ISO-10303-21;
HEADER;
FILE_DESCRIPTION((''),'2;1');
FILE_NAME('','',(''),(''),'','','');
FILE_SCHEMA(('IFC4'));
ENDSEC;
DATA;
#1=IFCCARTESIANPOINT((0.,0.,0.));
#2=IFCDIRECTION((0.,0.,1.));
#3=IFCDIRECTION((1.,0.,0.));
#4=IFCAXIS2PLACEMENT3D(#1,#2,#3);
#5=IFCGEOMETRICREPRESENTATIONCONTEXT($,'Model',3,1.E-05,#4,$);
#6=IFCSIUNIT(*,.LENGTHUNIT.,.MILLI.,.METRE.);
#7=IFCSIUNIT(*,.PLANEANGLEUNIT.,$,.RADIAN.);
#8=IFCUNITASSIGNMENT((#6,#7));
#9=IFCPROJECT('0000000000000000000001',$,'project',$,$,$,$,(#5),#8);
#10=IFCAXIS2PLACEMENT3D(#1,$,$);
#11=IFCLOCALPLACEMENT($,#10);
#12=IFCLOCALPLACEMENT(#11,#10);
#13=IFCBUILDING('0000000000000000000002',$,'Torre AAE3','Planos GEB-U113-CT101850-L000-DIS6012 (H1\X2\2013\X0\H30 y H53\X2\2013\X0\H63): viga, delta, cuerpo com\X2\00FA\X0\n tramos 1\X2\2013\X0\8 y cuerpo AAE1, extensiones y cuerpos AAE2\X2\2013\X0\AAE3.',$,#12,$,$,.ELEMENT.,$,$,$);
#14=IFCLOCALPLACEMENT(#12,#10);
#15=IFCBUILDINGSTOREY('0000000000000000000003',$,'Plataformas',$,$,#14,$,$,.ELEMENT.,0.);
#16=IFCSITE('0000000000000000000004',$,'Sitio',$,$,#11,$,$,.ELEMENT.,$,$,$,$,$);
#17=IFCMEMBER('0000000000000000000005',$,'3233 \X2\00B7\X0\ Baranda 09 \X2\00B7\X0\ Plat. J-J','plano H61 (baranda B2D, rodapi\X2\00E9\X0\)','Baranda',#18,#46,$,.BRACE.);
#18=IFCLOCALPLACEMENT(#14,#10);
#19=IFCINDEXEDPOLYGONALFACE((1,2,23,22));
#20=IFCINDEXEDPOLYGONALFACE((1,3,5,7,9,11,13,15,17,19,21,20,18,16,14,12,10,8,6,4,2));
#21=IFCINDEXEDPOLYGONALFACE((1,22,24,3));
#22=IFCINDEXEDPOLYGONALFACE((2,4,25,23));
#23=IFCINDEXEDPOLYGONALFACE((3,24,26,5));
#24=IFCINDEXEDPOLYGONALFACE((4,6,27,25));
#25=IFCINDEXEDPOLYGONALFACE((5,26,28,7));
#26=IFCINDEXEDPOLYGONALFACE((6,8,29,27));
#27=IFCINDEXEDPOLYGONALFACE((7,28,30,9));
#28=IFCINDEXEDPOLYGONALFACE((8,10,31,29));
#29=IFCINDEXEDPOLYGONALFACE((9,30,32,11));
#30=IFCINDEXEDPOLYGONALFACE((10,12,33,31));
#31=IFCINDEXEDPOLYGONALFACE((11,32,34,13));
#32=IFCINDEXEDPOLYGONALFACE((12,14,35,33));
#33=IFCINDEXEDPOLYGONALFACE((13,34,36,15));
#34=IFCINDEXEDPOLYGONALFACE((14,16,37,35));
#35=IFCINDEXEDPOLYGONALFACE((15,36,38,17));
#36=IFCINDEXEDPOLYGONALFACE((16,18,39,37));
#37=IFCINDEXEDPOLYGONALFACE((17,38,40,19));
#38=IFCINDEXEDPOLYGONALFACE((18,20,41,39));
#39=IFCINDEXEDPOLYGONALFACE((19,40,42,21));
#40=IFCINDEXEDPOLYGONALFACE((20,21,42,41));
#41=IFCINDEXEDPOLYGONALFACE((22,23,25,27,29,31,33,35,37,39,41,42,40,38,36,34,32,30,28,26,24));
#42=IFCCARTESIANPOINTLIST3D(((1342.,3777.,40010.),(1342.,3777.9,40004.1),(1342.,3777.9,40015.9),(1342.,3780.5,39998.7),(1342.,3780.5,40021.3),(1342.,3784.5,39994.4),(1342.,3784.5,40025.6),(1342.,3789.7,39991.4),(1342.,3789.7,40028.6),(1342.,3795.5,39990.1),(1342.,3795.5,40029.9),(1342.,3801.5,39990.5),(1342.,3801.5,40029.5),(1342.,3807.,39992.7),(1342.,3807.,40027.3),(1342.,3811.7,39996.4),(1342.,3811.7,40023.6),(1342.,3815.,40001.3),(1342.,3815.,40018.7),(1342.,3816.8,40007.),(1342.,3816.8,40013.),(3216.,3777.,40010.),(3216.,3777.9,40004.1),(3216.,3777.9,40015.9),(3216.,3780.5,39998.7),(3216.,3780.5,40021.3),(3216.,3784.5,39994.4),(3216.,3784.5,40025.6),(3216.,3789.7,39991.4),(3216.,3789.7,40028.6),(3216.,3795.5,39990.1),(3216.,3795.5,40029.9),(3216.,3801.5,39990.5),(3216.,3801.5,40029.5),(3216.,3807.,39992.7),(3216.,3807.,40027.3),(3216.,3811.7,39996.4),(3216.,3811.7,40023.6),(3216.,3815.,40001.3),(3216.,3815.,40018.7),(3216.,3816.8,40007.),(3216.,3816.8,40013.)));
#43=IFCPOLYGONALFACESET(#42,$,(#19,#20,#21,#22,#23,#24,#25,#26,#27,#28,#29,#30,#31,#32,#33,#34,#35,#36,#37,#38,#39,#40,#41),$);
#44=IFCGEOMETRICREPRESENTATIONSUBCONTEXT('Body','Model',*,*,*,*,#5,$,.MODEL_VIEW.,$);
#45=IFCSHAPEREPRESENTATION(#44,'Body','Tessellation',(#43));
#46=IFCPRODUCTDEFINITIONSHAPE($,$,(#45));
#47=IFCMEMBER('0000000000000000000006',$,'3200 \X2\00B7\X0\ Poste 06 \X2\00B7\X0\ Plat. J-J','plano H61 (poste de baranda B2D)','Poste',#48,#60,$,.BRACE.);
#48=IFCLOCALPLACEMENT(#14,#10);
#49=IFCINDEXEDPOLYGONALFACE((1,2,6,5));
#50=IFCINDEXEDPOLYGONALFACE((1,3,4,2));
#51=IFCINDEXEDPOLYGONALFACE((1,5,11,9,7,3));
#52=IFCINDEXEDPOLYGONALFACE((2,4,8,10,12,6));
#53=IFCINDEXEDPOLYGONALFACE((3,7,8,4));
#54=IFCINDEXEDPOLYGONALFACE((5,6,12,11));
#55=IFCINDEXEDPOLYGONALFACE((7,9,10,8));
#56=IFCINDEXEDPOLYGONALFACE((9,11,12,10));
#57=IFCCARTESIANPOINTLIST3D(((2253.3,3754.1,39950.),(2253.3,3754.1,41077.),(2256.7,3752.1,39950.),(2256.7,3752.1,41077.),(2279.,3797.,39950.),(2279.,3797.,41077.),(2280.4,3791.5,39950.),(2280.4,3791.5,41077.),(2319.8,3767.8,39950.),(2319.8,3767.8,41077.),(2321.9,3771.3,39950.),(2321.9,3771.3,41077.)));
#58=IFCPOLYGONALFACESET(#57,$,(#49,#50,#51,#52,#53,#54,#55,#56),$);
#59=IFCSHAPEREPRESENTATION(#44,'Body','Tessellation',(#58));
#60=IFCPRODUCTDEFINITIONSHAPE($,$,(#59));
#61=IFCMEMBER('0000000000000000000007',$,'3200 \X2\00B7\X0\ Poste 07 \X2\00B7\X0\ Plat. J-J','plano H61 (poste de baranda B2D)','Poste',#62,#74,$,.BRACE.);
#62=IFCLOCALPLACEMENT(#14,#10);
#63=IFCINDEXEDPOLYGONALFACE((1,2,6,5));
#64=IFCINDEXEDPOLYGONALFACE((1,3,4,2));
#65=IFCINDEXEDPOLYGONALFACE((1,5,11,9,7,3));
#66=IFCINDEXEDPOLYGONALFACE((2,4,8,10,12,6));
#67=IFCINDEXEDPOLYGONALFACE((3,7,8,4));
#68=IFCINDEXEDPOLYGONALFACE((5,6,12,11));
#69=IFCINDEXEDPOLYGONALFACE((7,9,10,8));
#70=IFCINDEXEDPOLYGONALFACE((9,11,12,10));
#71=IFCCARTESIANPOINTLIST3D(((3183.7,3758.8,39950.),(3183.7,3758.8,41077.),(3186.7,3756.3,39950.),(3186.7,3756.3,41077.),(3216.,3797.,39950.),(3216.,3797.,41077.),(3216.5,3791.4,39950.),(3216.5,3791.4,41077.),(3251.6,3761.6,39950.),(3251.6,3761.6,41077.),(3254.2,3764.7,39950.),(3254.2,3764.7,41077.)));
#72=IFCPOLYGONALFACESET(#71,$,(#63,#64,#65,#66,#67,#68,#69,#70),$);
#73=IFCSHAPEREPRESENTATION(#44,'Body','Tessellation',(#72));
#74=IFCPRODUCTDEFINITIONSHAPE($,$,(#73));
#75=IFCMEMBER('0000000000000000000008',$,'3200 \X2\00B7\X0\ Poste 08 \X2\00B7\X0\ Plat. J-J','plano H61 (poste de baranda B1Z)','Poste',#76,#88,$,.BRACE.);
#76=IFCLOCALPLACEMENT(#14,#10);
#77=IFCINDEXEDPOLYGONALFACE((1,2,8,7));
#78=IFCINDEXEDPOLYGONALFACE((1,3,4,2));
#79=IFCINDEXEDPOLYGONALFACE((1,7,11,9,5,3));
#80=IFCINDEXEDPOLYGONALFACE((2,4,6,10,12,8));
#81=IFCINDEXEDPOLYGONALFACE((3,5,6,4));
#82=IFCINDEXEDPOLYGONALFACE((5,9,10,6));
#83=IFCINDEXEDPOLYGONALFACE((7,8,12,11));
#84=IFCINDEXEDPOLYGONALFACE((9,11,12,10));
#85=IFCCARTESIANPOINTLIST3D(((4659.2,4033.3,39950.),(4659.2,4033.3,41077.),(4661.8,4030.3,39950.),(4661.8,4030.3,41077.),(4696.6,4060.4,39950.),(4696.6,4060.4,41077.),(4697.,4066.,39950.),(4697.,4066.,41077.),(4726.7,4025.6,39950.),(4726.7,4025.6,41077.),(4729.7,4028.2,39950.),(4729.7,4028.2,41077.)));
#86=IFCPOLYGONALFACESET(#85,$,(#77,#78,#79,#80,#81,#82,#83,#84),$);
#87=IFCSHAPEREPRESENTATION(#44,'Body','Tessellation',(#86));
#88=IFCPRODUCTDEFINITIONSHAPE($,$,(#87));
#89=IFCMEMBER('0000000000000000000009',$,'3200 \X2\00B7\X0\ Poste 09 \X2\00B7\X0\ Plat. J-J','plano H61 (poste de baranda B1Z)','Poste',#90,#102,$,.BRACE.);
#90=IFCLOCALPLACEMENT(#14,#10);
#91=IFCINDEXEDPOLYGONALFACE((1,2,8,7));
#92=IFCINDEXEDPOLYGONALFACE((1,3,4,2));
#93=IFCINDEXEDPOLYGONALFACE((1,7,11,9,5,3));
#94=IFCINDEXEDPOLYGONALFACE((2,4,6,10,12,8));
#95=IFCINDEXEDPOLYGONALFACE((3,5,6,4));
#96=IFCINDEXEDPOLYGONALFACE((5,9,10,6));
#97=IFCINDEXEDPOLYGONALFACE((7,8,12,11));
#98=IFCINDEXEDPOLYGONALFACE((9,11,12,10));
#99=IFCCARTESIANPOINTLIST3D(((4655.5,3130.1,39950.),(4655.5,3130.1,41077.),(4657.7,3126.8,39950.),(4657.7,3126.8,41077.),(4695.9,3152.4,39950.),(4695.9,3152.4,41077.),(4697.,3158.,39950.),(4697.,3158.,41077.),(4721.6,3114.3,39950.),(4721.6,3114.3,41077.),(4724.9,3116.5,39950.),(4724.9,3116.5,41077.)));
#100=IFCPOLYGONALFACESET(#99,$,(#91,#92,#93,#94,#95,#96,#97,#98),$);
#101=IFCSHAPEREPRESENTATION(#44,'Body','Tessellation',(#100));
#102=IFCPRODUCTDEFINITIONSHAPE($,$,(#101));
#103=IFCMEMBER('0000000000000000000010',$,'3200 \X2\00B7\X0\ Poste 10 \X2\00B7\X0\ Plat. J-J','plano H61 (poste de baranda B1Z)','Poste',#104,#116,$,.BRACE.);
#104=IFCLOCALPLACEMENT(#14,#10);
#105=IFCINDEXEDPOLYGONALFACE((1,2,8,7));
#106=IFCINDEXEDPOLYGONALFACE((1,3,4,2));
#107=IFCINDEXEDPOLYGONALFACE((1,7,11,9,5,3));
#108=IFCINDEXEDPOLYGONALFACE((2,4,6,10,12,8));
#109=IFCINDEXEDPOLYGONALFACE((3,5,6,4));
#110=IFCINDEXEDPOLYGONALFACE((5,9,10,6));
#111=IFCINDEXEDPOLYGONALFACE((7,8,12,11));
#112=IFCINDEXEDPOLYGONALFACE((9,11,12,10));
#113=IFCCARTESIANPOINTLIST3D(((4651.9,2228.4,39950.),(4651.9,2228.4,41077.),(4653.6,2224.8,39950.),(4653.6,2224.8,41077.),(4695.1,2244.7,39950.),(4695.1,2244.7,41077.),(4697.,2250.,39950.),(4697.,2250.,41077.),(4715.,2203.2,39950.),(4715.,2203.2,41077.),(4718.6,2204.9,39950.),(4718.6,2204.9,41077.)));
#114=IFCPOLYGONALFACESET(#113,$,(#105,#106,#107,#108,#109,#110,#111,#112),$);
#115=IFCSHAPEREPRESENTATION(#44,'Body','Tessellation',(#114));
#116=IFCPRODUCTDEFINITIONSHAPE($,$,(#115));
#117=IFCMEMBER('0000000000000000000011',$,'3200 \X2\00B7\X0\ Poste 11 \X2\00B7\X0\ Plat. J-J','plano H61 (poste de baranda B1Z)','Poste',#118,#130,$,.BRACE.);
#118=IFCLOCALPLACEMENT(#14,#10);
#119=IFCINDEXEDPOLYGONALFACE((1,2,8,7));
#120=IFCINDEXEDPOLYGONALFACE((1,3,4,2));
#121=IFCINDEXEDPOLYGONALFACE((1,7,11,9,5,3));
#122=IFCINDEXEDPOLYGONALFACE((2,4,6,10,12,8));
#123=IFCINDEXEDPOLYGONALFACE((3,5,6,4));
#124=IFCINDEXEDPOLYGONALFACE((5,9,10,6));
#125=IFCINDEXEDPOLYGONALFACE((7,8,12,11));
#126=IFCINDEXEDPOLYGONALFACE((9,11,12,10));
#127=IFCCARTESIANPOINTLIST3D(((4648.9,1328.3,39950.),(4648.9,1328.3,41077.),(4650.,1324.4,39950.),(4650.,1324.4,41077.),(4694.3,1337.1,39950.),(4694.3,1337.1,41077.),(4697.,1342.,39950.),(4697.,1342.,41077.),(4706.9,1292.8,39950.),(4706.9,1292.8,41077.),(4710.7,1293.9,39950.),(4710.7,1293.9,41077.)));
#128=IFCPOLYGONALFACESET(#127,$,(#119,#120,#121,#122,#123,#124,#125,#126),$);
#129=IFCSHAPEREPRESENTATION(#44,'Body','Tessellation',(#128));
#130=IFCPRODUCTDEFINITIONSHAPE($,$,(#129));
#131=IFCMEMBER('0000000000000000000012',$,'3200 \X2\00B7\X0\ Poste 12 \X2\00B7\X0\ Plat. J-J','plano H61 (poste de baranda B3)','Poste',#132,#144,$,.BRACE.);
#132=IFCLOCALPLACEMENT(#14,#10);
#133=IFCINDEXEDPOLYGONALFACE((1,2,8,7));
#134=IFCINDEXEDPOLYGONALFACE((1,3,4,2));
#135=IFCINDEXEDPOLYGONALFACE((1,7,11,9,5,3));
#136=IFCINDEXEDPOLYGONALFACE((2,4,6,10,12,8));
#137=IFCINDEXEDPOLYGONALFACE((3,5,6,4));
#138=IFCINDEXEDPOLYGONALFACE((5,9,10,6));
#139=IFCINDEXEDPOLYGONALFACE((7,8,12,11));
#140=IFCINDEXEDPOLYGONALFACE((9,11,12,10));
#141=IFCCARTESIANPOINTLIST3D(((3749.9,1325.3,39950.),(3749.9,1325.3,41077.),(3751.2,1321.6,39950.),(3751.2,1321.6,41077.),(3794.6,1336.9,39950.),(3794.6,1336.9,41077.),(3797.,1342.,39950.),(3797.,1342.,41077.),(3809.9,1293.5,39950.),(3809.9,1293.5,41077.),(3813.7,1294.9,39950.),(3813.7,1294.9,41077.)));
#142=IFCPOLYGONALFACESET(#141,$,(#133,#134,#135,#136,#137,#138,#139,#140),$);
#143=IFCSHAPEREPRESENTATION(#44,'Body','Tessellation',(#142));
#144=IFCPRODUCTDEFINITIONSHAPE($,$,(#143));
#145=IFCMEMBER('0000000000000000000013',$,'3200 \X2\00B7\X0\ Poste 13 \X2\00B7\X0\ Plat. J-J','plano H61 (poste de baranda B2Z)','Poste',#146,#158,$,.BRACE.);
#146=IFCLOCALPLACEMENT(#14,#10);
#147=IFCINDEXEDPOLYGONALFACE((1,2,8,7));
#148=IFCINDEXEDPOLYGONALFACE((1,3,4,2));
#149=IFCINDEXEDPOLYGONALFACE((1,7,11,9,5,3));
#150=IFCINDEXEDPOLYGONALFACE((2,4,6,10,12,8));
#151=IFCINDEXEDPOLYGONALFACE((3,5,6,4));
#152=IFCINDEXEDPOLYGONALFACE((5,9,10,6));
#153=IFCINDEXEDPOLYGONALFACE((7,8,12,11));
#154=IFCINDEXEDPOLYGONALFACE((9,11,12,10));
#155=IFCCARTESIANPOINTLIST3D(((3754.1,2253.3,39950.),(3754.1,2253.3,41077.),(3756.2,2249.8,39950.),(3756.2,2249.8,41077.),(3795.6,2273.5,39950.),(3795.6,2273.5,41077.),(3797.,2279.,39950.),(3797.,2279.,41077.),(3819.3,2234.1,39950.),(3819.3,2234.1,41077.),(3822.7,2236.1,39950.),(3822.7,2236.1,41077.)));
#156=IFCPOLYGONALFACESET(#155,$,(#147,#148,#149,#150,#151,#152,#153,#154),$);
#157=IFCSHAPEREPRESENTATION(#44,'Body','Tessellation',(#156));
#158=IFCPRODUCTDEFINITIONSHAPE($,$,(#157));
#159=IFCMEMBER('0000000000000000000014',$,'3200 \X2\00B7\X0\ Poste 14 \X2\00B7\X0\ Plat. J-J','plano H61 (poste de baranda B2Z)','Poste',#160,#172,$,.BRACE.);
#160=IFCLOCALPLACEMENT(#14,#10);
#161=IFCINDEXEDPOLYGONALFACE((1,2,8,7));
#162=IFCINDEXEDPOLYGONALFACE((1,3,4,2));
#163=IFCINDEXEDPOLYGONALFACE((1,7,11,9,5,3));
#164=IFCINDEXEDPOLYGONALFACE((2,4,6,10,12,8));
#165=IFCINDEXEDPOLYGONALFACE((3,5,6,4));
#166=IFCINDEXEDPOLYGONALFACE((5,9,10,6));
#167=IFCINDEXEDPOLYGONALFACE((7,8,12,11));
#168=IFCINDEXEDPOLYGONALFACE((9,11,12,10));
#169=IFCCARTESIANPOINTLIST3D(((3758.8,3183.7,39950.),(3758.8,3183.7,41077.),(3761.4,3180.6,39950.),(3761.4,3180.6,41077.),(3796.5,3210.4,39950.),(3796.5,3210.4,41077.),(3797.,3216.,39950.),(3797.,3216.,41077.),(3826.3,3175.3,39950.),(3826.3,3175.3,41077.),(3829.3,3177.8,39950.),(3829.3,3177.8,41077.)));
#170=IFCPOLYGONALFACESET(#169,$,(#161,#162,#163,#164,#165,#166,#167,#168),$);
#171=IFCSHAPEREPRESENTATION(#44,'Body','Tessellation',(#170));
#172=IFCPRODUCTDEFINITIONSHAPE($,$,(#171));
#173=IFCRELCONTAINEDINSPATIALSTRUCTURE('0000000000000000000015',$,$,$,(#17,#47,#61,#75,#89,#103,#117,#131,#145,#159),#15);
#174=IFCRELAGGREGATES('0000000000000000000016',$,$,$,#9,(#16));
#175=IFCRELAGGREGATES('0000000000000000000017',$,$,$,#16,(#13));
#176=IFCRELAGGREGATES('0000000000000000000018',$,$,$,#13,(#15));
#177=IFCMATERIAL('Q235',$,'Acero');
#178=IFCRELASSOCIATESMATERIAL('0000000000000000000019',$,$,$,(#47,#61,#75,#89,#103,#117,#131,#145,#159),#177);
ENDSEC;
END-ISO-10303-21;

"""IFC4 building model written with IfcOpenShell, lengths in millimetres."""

from ifc_helpers import new_model, si_unit, frame, frame_2d, origin, origin_with_axes, place, context, subcontext, project, spatial, circle, l_section, extrude, material, element, save


model = new_model("IFC4")

# Units and contexts
model_context = context("Model", 3, precision=1e-05, world=origin_with_axes())
body_context = subcontext(model_context, "Body", "Model", "MODEL_VIEW")
ifc_project = project(units=[si_unit("LENGTHUNIT", "METRE", prefix="MILLI"), si_unit("PLANEANGLEUNIT", "RADIAN")], contexts=[model_context])

# Site, building, storey
site_placement = place(None, origin())
site = spatial("IfcSite", under=ifc_project, at=site_placement, Name="Sitio", CompositionType="ELEMENT")
building_placement = place(site_placement, origin())
building = spatial("IfcBuilding", under=site, at=building_placement, Name="Torre AAE3", Description="Planos GEB-U113-CT101850-L000-DIS6012 (H1–H30 y H53–H63): viga, delta, cuerpo común tramos 1–8 y cuerpo AAE1, extensiones y cuerpos AAE2–AAE3.", CompositionType="ELEMENT")
storey_placement = place(building_placement, origin())
storey = spatial("IfcBuildingStorey", under=building, at=storey_placement, Name="Plataformas", CompositionType="ELEMENT", Elevation=0.0)

# Members
ifc_material = material(Name="Q235", Category="Acero")
member_1_placement = place(storey_placement, frame((1342.0, 3797.0, 40010.0), z_axis=(1.0, 0.0, 0.0), x_axis=(0.0, -1.0, 0.0)))
element("IfcMember", 1, at=member_1_placement, inside=storey, Name="3233 · Baranda 09 · Plat. J-J", Description="plano H61 (baranda B2D, rodapié)", ObjectType="Baranda", PredefinedType="BRACE", context=body_context, shape_type="SweptSolid", body=[
    extrude(circle(Radius=20.0), None, (0.0, 0.0, 1.0), 1874.0),
])
for number, where, z_axis, x_axis, name, description in (
    (2, (2279.0, 3797.0, 39950.0), (0.0, 0.0, 1.0), (-0.514629, -0.857413, 0.0), "3200 · Poste 06 · Plat. J-J", "plano H61 (poste de baranda B2D)"),
    (3, (3216.0, 3797.0, 39950.0), (0.0, 0.0, 1.0), (-0.646312, -0.763074, 0.0), "3200 · Poste 07 · Plat. J-J", "plano H61 (poste de baranda B2D)"),
    (4, (4697.0, 4066.0, 39950.0), (0.0, 0.0, 1.0), (-0.756066, -0.654495, 0.0), "3200 · Poste 08 · Plat. J-J", "plano H61 (poste de baranda B1Z)"),
    (5, (4697.0, 3158.0, 39950.0), (0.0, 0.0, 1.0), (-0.829869, -0.557958, 0.0), "3200 · Poste 09 · Plat. J-J", "plano H61 (poste de baranda B1Z)"),
    (6, (4697.0, 2250.0, 39950.0), (0.0, 0.0, 1.0), (-0.901864, -0.432019, 0.0), "3200 · Poste 10 · Plat. J-J", "plano H61 (poste de baranda B1Z)"),
    (7, (4697.0, 1342.0, 39950.0), (0.0, 0.0, 1.0), (-0.961524, -0.274721, 0.0), "3200 · Poste 11 · Plat. J-J", "plano H61 (poste de baranda B1Z)"),
    (8, (3797.0, 1342.0, 39950.0), (0.0, 0.0, 1.0), (-0.942844, -0.333236, 0.0), "3200 · Poste 12 · Plat. J-J", "plano H61 (poste de baranda B3)"),
    (9, (3797.0, 2279.0, 39950.0), (0.0, 0.0, 1.0), (-0.857413, -0.514629, 0.0), "3200 · Poste 13 · Plat. J-J", "plano H61 (poste de baranda B2Z)"),
    (10, (3797.0, 3216.0, 39950.0), (0.0, 0.0, 1.0), (-0.763074, -0.646312, 0.0), "3200 · Poste 14 · Plat. J-J", "plano H61 (poste de baranda B2Z)"),
):
    element("IfcMember", number, at=place(storey_placement, frame(where, z_axis=z_axis, x_axis=x_axis)), inside=storey, material=ifc_material, Name=name, Description=description, ObjectType="Poste", PredefinedType="BRACE", context=body_context, shape_type="SweptSolid", body=[
        extrude(l_section(Depth=50.0, Width=50.0, Thickness=4.0, at=frame_2d((25.0, 25.0))), None, (0.0, 0.0, 1.0), 1127.0),
    ])

save(model, "model.ifc")
